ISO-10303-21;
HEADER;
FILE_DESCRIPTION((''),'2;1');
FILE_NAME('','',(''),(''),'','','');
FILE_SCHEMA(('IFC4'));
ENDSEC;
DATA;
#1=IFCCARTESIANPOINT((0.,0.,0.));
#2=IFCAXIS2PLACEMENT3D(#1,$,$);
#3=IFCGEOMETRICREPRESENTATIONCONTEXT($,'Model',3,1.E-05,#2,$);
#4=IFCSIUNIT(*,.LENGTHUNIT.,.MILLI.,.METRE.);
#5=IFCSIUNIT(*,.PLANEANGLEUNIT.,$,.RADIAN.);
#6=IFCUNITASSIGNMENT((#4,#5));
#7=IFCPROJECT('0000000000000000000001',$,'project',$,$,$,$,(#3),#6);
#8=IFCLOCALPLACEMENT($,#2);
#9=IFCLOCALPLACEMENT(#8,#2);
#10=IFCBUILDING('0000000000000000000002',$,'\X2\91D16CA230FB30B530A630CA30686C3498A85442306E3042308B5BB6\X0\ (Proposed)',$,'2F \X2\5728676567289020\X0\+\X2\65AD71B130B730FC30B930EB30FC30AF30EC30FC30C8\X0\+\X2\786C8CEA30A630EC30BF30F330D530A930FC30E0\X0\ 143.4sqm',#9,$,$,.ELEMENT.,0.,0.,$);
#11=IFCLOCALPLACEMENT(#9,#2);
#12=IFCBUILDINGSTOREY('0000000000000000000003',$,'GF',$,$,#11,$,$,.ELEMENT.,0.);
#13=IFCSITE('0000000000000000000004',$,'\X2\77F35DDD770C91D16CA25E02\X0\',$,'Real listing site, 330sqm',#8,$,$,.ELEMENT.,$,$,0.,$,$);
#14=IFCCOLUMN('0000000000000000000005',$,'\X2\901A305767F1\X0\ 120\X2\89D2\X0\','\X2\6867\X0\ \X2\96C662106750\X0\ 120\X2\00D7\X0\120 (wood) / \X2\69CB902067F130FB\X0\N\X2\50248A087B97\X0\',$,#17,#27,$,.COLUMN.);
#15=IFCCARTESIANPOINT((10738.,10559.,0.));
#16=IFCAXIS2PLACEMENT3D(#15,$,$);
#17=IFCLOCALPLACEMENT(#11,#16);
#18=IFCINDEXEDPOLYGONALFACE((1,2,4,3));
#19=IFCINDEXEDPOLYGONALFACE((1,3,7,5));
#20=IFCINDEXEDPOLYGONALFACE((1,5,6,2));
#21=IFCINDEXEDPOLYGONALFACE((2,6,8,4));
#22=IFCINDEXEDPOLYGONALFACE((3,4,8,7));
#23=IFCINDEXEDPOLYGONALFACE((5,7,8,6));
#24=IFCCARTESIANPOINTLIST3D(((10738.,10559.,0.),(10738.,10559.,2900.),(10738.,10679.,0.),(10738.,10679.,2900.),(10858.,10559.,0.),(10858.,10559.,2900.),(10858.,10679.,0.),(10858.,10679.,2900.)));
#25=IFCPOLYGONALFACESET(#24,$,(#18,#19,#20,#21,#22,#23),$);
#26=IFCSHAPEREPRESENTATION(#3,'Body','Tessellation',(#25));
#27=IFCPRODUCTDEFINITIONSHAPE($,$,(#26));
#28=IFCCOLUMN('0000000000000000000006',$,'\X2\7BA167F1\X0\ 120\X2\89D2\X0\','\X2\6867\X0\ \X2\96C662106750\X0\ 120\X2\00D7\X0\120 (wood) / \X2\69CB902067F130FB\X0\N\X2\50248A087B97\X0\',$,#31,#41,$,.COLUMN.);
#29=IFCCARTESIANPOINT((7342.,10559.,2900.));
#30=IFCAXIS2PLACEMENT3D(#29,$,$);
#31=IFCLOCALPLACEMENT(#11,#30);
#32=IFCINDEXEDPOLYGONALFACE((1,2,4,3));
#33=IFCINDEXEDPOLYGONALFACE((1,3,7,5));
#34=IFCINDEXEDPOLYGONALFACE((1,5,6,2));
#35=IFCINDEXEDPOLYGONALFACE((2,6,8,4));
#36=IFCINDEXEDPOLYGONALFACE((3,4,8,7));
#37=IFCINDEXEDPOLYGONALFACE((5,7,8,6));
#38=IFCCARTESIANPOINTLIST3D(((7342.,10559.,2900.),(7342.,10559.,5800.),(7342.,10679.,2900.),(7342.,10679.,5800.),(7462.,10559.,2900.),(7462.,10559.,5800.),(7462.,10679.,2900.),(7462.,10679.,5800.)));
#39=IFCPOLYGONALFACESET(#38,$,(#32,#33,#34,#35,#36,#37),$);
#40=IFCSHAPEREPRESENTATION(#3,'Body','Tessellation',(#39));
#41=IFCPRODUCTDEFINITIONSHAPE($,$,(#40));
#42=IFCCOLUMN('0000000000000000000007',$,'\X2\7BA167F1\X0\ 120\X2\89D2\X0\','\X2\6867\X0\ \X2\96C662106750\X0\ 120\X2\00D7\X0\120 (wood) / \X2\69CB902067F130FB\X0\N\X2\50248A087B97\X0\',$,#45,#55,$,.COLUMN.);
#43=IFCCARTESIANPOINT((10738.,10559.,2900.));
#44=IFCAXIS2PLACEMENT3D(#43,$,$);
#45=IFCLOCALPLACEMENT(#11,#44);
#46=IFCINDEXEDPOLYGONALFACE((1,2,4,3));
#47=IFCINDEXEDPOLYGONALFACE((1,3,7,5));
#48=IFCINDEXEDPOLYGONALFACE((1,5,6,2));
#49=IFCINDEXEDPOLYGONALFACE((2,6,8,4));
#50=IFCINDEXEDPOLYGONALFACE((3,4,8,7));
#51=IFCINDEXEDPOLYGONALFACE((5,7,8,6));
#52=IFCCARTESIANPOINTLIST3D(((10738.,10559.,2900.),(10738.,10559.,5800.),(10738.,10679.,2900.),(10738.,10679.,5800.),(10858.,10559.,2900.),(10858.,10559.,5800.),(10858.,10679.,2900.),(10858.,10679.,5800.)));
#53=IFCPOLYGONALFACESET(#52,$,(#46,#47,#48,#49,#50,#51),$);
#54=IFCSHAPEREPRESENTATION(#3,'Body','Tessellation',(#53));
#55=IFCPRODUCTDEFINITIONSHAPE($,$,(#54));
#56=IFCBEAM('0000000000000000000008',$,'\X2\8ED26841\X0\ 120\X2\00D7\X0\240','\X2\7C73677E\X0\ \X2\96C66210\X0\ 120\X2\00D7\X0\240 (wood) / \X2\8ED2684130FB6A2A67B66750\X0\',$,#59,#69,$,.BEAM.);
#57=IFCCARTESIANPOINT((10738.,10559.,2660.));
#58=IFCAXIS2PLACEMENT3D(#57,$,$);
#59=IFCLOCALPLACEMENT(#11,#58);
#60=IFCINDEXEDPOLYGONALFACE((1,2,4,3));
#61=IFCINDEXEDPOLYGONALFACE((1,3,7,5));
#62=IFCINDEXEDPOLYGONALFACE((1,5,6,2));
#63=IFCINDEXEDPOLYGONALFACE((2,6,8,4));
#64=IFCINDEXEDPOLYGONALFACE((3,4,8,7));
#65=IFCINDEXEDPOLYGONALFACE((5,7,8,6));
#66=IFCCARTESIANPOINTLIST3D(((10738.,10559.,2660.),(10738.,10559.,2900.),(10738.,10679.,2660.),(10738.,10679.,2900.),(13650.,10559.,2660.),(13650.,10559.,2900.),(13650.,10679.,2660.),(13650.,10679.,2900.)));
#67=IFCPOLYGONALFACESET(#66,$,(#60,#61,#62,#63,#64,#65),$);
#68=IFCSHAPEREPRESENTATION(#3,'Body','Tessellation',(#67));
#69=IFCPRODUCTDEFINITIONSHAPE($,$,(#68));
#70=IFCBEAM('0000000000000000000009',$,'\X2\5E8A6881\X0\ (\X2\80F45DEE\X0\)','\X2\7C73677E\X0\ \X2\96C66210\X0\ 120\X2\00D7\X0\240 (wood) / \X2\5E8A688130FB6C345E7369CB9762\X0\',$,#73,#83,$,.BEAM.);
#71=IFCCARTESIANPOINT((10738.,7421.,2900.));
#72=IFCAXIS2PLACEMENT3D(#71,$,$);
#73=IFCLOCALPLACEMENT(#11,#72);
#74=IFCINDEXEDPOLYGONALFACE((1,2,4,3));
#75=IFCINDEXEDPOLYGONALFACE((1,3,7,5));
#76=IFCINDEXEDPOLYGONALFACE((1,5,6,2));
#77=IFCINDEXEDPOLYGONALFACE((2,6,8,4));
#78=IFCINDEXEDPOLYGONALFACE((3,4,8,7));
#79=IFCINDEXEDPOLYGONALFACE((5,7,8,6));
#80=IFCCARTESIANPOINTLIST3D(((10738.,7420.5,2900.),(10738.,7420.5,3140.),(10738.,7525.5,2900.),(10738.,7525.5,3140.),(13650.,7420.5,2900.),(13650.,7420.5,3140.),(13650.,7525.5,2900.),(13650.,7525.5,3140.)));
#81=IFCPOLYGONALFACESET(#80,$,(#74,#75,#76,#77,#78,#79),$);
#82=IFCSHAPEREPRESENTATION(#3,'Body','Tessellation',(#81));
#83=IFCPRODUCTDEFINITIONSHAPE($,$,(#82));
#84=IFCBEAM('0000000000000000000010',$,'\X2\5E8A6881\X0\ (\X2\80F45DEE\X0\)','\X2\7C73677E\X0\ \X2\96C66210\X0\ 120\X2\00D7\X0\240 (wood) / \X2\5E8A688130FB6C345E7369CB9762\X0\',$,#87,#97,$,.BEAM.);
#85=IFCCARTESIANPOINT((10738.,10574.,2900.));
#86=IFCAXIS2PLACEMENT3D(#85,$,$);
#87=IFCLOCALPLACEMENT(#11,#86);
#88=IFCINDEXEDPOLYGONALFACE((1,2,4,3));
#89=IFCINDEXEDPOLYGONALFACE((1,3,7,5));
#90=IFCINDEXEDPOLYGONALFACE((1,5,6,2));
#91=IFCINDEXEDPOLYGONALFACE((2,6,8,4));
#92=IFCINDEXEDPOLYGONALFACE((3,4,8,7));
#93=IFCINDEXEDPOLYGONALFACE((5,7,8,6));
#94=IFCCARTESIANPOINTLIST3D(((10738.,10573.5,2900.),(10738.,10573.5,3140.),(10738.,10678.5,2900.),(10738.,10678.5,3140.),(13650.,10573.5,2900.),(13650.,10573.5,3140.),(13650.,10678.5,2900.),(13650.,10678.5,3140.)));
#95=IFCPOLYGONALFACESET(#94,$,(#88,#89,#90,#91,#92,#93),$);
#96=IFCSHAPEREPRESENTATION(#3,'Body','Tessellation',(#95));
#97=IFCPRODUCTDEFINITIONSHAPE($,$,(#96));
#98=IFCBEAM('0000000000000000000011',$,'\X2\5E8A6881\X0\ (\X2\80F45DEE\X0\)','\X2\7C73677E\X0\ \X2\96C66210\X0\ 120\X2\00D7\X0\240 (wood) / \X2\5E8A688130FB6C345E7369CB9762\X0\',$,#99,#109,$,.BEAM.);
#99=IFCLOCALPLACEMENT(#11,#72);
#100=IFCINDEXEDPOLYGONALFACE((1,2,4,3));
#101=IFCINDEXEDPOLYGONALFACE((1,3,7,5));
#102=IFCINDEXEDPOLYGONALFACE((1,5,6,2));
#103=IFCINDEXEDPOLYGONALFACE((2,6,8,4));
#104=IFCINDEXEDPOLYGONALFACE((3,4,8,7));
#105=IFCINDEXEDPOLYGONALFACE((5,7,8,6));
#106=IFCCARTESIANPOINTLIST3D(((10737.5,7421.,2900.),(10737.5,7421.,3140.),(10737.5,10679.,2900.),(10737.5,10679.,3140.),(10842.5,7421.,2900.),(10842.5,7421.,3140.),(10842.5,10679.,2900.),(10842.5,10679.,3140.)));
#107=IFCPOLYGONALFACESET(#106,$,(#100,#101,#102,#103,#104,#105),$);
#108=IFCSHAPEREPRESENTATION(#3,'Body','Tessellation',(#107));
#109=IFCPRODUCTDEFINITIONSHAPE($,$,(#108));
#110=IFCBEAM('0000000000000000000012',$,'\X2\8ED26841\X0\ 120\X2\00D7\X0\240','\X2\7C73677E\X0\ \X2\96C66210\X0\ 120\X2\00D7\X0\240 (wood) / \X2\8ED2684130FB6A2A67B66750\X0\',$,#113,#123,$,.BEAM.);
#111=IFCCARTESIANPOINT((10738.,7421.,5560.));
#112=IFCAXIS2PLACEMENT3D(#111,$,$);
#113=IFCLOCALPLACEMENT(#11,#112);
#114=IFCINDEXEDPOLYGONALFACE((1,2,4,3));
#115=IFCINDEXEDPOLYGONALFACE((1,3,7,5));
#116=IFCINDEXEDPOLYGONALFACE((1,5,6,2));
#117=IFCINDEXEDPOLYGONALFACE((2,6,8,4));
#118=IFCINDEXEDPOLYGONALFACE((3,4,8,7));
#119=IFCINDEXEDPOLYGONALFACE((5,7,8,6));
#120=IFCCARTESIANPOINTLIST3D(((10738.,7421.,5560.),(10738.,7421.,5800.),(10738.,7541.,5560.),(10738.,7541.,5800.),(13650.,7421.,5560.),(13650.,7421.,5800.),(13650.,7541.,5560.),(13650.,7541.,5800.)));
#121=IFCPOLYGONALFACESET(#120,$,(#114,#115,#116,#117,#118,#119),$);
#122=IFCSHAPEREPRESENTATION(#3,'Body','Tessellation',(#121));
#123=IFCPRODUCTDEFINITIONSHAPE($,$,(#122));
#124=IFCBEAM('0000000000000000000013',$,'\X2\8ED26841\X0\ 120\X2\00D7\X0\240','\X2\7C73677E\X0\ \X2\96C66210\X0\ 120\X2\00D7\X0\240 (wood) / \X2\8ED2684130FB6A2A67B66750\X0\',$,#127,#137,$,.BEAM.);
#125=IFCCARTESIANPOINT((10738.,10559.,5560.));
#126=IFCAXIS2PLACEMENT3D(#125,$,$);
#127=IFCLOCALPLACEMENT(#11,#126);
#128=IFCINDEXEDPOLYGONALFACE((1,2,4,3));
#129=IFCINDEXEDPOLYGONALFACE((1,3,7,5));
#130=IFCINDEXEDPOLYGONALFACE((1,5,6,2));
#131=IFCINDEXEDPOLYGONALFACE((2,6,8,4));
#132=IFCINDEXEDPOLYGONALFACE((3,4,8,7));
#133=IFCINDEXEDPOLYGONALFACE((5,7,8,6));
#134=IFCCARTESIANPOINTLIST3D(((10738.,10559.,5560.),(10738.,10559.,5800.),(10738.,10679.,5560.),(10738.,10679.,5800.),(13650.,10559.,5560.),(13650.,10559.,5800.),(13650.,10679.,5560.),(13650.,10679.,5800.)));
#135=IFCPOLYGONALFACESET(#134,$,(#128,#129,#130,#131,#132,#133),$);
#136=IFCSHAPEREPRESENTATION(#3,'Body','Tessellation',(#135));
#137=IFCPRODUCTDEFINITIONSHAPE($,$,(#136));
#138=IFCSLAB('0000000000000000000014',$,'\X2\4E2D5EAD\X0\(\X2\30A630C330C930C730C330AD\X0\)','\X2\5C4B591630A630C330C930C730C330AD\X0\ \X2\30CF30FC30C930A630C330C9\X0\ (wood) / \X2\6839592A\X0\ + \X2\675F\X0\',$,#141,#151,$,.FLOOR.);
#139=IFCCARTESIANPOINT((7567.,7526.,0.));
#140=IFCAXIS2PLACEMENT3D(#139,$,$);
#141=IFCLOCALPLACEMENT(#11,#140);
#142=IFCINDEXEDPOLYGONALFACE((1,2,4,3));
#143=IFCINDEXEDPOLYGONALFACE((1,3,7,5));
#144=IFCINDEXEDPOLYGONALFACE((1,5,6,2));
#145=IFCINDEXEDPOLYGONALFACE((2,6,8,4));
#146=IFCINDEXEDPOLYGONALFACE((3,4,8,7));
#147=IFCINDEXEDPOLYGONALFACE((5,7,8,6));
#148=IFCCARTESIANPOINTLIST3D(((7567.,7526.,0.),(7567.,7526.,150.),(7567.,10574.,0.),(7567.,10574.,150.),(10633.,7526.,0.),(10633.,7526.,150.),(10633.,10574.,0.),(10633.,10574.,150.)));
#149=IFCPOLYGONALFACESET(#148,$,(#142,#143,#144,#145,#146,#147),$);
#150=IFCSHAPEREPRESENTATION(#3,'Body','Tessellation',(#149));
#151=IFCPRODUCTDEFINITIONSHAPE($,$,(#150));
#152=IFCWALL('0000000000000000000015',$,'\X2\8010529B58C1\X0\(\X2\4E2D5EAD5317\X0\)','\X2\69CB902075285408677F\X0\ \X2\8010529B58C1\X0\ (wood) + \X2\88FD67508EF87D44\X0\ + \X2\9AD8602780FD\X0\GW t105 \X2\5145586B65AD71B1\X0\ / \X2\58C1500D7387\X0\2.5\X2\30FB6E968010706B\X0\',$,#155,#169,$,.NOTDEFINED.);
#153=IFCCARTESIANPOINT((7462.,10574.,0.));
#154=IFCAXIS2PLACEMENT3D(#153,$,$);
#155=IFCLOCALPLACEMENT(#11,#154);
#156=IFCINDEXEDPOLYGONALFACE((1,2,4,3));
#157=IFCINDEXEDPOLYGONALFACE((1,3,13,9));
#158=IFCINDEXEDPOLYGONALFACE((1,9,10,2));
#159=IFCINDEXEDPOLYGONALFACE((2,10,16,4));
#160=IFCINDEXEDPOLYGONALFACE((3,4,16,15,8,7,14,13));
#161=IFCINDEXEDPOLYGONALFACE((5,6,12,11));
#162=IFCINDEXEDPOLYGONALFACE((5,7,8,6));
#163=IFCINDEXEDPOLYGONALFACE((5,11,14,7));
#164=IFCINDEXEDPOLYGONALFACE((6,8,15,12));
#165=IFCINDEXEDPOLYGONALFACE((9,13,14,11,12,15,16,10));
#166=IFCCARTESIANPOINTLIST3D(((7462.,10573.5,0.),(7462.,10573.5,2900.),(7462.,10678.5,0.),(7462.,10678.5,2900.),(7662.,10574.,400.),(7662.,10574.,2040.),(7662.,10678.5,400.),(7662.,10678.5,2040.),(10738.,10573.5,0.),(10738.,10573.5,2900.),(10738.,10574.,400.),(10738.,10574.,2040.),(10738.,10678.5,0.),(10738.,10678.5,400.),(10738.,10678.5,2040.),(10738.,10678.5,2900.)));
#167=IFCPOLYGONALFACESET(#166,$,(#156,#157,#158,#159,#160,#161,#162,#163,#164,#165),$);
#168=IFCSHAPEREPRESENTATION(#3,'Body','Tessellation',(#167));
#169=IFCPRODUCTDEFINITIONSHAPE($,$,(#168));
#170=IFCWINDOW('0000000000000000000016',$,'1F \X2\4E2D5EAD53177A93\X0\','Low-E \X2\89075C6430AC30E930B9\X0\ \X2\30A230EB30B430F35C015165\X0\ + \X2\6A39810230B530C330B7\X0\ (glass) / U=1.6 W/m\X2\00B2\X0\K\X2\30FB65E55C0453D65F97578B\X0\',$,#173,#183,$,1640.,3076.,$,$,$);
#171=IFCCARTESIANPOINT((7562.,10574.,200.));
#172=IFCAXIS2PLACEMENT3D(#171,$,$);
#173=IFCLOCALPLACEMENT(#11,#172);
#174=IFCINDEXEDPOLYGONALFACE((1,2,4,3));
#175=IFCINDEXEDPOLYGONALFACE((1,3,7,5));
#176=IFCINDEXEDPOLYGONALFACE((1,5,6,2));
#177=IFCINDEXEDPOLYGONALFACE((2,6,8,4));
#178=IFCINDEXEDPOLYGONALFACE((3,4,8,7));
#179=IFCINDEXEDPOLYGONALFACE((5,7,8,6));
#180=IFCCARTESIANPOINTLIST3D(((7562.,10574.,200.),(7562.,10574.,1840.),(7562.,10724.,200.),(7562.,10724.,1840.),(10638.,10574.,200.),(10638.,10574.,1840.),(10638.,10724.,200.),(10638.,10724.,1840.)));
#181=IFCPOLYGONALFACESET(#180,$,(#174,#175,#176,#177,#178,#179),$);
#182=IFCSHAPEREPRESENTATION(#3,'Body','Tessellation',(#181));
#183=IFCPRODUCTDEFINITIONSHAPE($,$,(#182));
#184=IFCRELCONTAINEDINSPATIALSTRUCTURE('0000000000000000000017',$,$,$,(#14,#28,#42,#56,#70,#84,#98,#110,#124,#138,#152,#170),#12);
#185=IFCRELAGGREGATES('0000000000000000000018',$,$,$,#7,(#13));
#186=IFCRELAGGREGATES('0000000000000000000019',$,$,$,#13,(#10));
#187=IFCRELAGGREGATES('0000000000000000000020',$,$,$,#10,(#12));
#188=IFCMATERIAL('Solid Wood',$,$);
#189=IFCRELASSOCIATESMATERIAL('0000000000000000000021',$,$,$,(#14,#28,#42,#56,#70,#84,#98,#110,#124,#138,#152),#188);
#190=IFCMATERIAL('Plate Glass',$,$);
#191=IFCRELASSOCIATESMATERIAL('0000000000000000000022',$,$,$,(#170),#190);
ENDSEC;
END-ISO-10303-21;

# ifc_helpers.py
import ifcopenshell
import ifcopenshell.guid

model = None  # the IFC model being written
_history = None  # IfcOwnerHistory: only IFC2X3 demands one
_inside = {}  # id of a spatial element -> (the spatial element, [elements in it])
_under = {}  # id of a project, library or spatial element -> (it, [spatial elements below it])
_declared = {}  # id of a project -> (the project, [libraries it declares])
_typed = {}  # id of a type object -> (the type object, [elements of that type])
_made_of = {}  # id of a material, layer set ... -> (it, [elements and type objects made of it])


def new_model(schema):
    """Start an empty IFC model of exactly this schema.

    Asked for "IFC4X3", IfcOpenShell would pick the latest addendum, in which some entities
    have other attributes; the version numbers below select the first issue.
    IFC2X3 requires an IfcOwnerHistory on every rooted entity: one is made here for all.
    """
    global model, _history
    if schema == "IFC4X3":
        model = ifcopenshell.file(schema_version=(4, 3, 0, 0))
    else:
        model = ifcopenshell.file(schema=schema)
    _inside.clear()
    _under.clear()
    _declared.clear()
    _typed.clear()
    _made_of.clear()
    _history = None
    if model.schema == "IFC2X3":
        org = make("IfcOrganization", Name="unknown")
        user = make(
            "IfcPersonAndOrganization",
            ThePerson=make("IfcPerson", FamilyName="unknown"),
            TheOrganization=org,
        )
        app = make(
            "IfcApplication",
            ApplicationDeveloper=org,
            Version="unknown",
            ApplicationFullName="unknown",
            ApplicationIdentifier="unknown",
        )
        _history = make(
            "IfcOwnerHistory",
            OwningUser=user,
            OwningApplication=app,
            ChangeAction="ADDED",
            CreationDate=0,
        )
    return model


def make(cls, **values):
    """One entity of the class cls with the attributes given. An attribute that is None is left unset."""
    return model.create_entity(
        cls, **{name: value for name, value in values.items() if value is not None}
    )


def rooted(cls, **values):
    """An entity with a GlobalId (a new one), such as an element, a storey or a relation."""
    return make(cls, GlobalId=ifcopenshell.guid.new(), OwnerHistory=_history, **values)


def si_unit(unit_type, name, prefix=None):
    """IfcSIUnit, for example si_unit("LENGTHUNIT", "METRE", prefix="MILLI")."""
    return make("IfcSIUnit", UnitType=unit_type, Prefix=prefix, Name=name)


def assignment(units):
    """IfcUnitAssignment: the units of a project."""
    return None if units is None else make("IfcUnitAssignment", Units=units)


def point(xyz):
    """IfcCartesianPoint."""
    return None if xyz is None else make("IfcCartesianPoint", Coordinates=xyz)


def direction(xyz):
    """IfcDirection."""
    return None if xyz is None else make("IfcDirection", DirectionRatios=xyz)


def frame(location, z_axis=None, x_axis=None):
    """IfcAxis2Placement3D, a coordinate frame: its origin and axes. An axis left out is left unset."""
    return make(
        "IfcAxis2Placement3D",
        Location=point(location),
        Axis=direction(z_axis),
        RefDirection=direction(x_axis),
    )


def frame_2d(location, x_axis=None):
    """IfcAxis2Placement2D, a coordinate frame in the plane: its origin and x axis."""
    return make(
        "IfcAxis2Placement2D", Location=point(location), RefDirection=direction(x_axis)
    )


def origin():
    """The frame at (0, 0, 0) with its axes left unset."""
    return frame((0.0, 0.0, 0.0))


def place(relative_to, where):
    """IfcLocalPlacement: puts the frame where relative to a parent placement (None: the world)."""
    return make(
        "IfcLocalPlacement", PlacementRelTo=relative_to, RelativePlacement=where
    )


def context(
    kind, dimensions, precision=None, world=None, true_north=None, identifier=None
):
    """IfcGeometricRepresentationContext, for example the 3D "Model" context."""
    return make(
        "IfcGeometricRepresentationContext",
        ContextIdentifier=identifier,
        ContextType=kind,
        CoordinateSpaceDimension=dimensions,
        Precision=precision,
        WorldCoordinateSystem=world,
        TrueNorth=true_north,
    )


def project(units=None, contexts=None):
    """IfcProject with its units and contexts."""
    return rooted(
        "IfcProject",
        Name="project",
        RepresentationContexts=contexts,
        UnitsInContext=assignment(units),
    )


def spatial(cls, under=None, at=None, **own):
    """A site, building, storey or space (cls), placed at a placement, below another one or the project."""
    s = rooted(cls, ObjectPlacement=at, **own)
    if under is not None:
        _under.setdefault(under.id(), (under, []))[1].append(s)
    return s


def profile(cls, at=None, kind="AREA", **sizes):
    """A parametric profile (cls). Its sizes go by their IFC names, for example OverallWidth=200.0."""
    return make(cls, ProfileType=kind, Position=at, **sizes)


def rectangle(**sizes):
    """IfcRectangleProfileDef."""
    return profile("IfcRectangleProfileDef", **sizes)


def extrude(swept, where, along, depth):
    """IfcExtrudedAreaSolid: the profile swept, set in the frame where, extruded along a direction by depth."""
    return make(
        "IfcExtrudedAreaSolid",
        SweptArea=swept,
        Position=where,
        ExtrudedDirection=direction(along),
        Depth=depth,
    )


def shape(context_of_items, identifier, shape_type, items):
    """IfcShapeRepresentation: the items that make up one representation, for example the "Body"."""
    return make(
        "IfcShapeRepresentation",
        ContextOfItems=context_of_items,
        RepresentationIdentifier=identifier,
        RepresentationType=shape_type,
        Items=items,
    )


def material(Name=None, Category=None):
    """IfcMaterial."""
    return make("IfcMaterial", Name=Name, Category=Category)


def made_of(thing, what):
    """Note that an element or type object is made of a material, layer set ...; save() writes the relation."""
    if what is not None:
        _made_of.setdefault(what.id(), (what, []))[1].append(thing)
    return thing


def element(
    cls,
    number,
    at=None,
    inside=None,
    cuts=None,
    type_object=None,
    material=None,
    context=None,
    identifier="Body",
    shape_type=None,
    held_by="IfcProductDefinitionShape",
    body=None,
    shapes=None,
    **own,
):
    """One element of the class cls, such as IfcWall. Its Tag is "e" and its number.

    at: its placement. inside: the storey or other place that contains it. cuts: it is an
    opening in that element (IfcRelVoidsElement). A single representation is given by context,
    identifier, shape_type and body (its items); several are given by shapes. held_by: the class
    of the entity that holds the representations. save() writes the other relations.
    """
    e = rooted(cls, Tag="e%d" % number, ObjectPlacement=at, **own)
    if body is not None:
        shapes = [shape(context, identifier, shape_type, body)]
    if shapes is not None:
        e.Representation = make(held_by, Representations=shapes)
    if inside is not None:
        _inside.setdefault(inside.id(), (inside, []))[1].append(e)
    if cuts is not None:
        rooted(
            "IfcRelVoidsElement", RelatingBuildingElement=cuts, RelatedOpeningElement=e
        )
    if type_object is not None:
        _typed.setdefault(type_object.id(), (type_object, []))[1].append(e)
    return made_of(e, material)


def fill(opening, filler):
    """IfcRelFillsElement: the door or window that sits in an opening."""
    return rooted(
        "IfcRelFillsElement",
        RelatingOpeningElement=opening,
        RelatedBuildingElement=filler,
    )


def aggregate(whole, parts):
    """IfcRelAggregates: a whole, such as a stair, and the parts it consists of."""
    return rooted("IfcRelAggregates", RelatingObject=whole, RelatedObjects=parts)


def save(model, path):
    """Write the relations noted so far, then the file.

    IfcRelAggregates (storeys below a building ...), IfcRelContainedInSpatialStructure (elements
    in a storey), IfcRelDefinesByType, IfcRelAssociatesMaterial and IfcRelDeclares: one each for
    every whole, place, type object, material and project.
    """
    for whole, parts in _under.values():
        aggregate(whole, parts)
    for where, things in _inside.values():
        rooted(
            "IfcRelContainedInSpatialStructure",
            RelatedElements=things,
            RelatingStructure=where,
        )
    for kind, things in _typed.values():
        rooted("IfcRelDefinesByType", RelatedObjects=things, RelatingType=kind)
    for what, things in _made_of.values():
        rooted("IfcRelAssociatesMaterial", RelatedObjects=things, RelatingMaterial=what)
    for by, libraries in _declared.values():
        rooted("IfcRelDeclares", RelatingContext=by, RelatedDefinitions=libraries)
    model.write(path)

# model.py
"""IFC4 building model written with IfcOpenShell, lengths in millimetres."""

from ifc_helpers import new_model, si_unit, frame, frame_2d, origin, place, context, project, spatial, rectangle, extrude, material, element, fill, save


model = new_model("IFC4")

# Units and contexts
model_context = context("Model", 3, precision=1e-05, world=origin())
ifc_project = project(units=[si_unit("LENGTHUNIT", "METRE", prefix="MILLI"), si_unit("PLANEANGLEUNIT", "RADIAN")], contexts=[model_context])

# Site, building, storey
site_placement = place(None, origin())
site = spatial("IfcSite", under=ifc_project, at=site_placement, Name="石川県金沢市", ObjectType="Real listing site, 330sqm", CompositionType="ELEMENT", RefElevation=0.0)
building_placement = place(site_placement, origin())
building = spatial("IfcBuilding", under=site, at=building_placement, Name="金沢・サウナと水風呂のある家 (Proposed)", ObjectType="2F 在来木造+断熱シースルークレート+硬質ウレタンフォーム 143.4sqm", CompositionType="ELEMENT", ElevationOfRefHeight=0.0, ElevationOfTerrain=0.0)
storey_placement = place(building_placement, origin())
storey = spatial("IfcBuildingStorey", under=building, at=storey_placement, Name="GF", CompositionType="ELEMENT", Elevation=0.0)

# Columns
ifc_material_1 = material(Name="Solid Wood")
column_1_placement = place(storey_placement, frame((10738.0, 10559.0, 0.0)))
element("IfcColumn", 1, at=column_1_placement, inside=storey, material=ifc_material_1, Name="通し柱 120角", Description="桧 集成材 120×120 (wood) / 構造柱・N値計算", PredefinedType="COLUMN", context=model_context, shape_type="SweptSolid", body=[
    extrude(rectangle(XDim=120.0, YDim=120.0, at=frame_2d((60.0, 60.0))), frame((10738.0, 10559.0, 0.0)), (0.0, 0.0, 1.0), 2900.0),
])
column_2_placement = place(storey_placement, frame((7342.0, 10559.0, 2900.0)))
element("IfcColumn", 2, at=column_2_placement, inside=storey, material=ifc_material_1, Name="管柱 120角", Description="桧 集成材 120×120 (wood) / 構造柱・N値計算", PredefinedType="COLUMN", context=model_context, shape_type="SweptSolid", body=[
    extrude(rectangle(XDim=120.0, YDim=120.0, at=frame_2d((60.0, 60.0))), frame((7342.0, 10559.0, 2900.0)), (0.0, 0.0, 1.0), 2900.0),
])
column_3_placement = place(storey_placement, frame((10738.0, 10559.0, 2900.0)))
element("IfcColumn", 3, at=column_3_placement, inside=storey, material=ifc_material_1, Name="管柱 120角", Description="桧 集成材 120×120 (wood) / 構造柱・N値計算", PredefinedType="COLUMN", context=model_context, shape_type="SweptSolid", body=[
    extrude(rectangle(XDim=120.0, YDim=120.0, at=frame_2d((60.0, 60.0))), frame((10738.0, 10559.0, 2900.0)), (0.0, 0.0, 1.0), 2900.0),
])

# Beams
beam_1_placement = place(storey_placement, frame((10738.0, 10559.0, 2660.0)))
element("IfcBeam", 4, at=beam_1_placement, inside=storey, material=ifc_material_1, Name="軒桁 120×240", Description="米松 集成 120×240 (wood) / 軒桁・横架材", PredefinedType="BEAM", context=model_context, shape_type="SweptSolid", body=[
    extrude(rectangle(XDim=2912.0, YDim=120.0, at=frame_2d((1456.0, 60.0))), frame((10738.0, 10559.0, 2660.0)), (0.0, 0.0, 1.0), 240.0),
])
beam_2_placement = place(storey_placement, frame((10738.0, 7421.0, 2900.0)))
element("IfcBeam", 5, at=beam_2_placement, inside=storey, material=ifc_material_1, Name="床梁 (胴差)", Description="米松 集成 120×240 (wood) / 床梁・水平構面", PredefinedType="BEAM", context=model_context, shape_type="SweptSolid", body=[
    extrude(rectangle(XDim=2912.0, YDim=105.0, at=frame_2d((1456.0, 52.0))), frame((10738.0, 7421.0, 2900.0)), (0.0, 0.0, 1.0), 240.0),
])
beam_3_placement = place(storey_placement, frame((10738.0, 10574.0, 2900.0)))
element("IfcBeam", 6, at=beam_3_placement, inside=storey, material=ifc_material_1, Name="床梁 (胴差)", Description="米松 集成 120×240 (wood) / 床梁・水平構面", PredefinedType="BEAM", context=model_context, shape_type="SweptSolid", body=[
    extrude(rectangle(XDim=2912.0, YDim=105.0, at=frame_2d((1456.0, 52.0))), frame((10738.0, 10574.0, 2900.0)), (0.0, 0.0, 1.0), 240.0),
])
beam_4_placement = place(storey_placement, frame((10738.0, 7421.0, 2900.0)))
element("IfcBeam", 7, at=beam_4_placement, inside=storey, material=ifc_material_1, Name="床梁 (胴差)", Description="米松 集成 120×240 (wood) / 床梁・水平構面", PredefinedType="BEAM", context=model_context, shape_type="SweptSolid", body=[
    extrude(rectangle(XDim=105.0, YDim=3258.0, at=frame_2d((52.0, 1629.0))), frame((10738.0, 7421.0, 2900.0)), (0.0, 0.0, 1.0), 240.0),
])
beam_5_placement = place(storey_placement, frame((10738.0, 7421.0, 5560.0)))
element("IfcBeam", 8, at=beam_5_placement, inside=storey, material=ifc_material_1, Name="軒桁 120×240", Description="米松 集成 120×240 (wood) / 軒桁・横架材", PredefinedType="BEAM", context=model_context, shape_type="SweptSolid", body=[
    extrude(rectangle(XDim=2912.0, YDim=120.0, at=frame_2d((1456.0, 60.0))), frame((10738.0, 7421.0, 5560.0)), (0.0, 0.0, 1.0), 240.0),
])
beam_6_placement = place(storey_placement, frame((10738.0, 10559.0, 5560.0)))
element("IfcBeam", 9, at=beam_6_placement, inside=storey, material=ifc_material_1, Name="軒桁 120×240", Description="米松 集成 120×240 (wood) / 軒桁・横架材", PredefinedType="BEAM", context=model_context, shape_type="SweptSolid", body=[
    extrude(rectangle(XDim=2912.0, YDim=120.0, at=frame_2d((1456.0, 60.0))), frame((10738.0, 10559.0, 5560.0)), (0.0, 0.0, 1.0), 240.0),
])

# Slab
slab_placement = place(storey_placement, frame((7567.0, 7526.0, 0.0)))
element("IfcSlab", 10, at=slab_placement, inside=storey, material=ifc_material_1, Name="中庭(ウッドデッキ)", Description="屋外ウッドデッキ ハードウッド (wood) / 根太 + 束", PredefinedType="FLOOR", context=model_context, shape_type="SweptSolid", body=[
    extrude(rectangle(XDim=3066.0, YDim=3048.0, at=frame_2d((1533.0, 1524.0))), frame((7567.0, 7526.0, 0.0)), (0.0, 0.0, 1.0), 150.0),
])

# Wall, opening, window
wall_1_placement = place(storey_placement, frame((7462.0, 10574.0, 0.0)))
wall_1 = element("IfcWall", 11, at=wall_1_placement, inside=storey, material=ifc_material_1, Name="耐力壁(中庭北)", Description="構造用合板 耐力壁 (wood) + 製材軸組 + 高性能GW t105 充填断熱 / 壁倍率2.5・準耐火", PredefinedType="NOTDEFINED", context=model_context, shape_type="SweptSolid", body=[
    extrude(rectangle(XDim=3276.0, YDim=105.0, at=frame_2d((1638.0, 52.0))), frame((7462.0, 10574.0, 0.0)), (0.0, 0.0, 1.0), 2900.0),
])
opening_1_placement = place(storey_placement, frame((7562.0, 10574.0, 200.0)))
opening_1 = element("IfcOpeningElement", 12, at=opening_1_placement, cuts=wall_1, PredefinedType="NOTDEFINED", context=model_context, shape_type="SweptSolid", body=[
    extrude(rectangle(XDim=3076.0, YDim=150.0, at=frame_2d((1538.0, 75.0))), frame((7562.0, 10574.0, 200.0)), (0.0, 0.0, 1.0), 1640.0),
])
ifc_material_2 = material(Name="Plate Glass")
window_1_placement = place(storey_placement, frame((7562.0, 10574.0, 200.0)))
window_1 = element("IfcWindow", 13, at=window_1_placement, inside=storey, material=ifc_material_2, Name="1F 中庭北窓", Description="Low-E 複層ガラス アルゴン封入 + 樹脂サッシ (glass) / U=1.6 W/m²K・日射取得型", OverallHeight=1640.0, OverallWidth=3076.0, context=model_context, shape_type="SweptSolid", body=[
    extrude(rectangle(XDim=3076.0, YDim=150.0, at=frame_2d((1538.0, 75.0))), frame((7562.0, 10574.0, 200.0)), (0.0, 0.0, 1.0), 1640.0),
])
fill(opening_1, window_1)

save(model, "model.ifc")
